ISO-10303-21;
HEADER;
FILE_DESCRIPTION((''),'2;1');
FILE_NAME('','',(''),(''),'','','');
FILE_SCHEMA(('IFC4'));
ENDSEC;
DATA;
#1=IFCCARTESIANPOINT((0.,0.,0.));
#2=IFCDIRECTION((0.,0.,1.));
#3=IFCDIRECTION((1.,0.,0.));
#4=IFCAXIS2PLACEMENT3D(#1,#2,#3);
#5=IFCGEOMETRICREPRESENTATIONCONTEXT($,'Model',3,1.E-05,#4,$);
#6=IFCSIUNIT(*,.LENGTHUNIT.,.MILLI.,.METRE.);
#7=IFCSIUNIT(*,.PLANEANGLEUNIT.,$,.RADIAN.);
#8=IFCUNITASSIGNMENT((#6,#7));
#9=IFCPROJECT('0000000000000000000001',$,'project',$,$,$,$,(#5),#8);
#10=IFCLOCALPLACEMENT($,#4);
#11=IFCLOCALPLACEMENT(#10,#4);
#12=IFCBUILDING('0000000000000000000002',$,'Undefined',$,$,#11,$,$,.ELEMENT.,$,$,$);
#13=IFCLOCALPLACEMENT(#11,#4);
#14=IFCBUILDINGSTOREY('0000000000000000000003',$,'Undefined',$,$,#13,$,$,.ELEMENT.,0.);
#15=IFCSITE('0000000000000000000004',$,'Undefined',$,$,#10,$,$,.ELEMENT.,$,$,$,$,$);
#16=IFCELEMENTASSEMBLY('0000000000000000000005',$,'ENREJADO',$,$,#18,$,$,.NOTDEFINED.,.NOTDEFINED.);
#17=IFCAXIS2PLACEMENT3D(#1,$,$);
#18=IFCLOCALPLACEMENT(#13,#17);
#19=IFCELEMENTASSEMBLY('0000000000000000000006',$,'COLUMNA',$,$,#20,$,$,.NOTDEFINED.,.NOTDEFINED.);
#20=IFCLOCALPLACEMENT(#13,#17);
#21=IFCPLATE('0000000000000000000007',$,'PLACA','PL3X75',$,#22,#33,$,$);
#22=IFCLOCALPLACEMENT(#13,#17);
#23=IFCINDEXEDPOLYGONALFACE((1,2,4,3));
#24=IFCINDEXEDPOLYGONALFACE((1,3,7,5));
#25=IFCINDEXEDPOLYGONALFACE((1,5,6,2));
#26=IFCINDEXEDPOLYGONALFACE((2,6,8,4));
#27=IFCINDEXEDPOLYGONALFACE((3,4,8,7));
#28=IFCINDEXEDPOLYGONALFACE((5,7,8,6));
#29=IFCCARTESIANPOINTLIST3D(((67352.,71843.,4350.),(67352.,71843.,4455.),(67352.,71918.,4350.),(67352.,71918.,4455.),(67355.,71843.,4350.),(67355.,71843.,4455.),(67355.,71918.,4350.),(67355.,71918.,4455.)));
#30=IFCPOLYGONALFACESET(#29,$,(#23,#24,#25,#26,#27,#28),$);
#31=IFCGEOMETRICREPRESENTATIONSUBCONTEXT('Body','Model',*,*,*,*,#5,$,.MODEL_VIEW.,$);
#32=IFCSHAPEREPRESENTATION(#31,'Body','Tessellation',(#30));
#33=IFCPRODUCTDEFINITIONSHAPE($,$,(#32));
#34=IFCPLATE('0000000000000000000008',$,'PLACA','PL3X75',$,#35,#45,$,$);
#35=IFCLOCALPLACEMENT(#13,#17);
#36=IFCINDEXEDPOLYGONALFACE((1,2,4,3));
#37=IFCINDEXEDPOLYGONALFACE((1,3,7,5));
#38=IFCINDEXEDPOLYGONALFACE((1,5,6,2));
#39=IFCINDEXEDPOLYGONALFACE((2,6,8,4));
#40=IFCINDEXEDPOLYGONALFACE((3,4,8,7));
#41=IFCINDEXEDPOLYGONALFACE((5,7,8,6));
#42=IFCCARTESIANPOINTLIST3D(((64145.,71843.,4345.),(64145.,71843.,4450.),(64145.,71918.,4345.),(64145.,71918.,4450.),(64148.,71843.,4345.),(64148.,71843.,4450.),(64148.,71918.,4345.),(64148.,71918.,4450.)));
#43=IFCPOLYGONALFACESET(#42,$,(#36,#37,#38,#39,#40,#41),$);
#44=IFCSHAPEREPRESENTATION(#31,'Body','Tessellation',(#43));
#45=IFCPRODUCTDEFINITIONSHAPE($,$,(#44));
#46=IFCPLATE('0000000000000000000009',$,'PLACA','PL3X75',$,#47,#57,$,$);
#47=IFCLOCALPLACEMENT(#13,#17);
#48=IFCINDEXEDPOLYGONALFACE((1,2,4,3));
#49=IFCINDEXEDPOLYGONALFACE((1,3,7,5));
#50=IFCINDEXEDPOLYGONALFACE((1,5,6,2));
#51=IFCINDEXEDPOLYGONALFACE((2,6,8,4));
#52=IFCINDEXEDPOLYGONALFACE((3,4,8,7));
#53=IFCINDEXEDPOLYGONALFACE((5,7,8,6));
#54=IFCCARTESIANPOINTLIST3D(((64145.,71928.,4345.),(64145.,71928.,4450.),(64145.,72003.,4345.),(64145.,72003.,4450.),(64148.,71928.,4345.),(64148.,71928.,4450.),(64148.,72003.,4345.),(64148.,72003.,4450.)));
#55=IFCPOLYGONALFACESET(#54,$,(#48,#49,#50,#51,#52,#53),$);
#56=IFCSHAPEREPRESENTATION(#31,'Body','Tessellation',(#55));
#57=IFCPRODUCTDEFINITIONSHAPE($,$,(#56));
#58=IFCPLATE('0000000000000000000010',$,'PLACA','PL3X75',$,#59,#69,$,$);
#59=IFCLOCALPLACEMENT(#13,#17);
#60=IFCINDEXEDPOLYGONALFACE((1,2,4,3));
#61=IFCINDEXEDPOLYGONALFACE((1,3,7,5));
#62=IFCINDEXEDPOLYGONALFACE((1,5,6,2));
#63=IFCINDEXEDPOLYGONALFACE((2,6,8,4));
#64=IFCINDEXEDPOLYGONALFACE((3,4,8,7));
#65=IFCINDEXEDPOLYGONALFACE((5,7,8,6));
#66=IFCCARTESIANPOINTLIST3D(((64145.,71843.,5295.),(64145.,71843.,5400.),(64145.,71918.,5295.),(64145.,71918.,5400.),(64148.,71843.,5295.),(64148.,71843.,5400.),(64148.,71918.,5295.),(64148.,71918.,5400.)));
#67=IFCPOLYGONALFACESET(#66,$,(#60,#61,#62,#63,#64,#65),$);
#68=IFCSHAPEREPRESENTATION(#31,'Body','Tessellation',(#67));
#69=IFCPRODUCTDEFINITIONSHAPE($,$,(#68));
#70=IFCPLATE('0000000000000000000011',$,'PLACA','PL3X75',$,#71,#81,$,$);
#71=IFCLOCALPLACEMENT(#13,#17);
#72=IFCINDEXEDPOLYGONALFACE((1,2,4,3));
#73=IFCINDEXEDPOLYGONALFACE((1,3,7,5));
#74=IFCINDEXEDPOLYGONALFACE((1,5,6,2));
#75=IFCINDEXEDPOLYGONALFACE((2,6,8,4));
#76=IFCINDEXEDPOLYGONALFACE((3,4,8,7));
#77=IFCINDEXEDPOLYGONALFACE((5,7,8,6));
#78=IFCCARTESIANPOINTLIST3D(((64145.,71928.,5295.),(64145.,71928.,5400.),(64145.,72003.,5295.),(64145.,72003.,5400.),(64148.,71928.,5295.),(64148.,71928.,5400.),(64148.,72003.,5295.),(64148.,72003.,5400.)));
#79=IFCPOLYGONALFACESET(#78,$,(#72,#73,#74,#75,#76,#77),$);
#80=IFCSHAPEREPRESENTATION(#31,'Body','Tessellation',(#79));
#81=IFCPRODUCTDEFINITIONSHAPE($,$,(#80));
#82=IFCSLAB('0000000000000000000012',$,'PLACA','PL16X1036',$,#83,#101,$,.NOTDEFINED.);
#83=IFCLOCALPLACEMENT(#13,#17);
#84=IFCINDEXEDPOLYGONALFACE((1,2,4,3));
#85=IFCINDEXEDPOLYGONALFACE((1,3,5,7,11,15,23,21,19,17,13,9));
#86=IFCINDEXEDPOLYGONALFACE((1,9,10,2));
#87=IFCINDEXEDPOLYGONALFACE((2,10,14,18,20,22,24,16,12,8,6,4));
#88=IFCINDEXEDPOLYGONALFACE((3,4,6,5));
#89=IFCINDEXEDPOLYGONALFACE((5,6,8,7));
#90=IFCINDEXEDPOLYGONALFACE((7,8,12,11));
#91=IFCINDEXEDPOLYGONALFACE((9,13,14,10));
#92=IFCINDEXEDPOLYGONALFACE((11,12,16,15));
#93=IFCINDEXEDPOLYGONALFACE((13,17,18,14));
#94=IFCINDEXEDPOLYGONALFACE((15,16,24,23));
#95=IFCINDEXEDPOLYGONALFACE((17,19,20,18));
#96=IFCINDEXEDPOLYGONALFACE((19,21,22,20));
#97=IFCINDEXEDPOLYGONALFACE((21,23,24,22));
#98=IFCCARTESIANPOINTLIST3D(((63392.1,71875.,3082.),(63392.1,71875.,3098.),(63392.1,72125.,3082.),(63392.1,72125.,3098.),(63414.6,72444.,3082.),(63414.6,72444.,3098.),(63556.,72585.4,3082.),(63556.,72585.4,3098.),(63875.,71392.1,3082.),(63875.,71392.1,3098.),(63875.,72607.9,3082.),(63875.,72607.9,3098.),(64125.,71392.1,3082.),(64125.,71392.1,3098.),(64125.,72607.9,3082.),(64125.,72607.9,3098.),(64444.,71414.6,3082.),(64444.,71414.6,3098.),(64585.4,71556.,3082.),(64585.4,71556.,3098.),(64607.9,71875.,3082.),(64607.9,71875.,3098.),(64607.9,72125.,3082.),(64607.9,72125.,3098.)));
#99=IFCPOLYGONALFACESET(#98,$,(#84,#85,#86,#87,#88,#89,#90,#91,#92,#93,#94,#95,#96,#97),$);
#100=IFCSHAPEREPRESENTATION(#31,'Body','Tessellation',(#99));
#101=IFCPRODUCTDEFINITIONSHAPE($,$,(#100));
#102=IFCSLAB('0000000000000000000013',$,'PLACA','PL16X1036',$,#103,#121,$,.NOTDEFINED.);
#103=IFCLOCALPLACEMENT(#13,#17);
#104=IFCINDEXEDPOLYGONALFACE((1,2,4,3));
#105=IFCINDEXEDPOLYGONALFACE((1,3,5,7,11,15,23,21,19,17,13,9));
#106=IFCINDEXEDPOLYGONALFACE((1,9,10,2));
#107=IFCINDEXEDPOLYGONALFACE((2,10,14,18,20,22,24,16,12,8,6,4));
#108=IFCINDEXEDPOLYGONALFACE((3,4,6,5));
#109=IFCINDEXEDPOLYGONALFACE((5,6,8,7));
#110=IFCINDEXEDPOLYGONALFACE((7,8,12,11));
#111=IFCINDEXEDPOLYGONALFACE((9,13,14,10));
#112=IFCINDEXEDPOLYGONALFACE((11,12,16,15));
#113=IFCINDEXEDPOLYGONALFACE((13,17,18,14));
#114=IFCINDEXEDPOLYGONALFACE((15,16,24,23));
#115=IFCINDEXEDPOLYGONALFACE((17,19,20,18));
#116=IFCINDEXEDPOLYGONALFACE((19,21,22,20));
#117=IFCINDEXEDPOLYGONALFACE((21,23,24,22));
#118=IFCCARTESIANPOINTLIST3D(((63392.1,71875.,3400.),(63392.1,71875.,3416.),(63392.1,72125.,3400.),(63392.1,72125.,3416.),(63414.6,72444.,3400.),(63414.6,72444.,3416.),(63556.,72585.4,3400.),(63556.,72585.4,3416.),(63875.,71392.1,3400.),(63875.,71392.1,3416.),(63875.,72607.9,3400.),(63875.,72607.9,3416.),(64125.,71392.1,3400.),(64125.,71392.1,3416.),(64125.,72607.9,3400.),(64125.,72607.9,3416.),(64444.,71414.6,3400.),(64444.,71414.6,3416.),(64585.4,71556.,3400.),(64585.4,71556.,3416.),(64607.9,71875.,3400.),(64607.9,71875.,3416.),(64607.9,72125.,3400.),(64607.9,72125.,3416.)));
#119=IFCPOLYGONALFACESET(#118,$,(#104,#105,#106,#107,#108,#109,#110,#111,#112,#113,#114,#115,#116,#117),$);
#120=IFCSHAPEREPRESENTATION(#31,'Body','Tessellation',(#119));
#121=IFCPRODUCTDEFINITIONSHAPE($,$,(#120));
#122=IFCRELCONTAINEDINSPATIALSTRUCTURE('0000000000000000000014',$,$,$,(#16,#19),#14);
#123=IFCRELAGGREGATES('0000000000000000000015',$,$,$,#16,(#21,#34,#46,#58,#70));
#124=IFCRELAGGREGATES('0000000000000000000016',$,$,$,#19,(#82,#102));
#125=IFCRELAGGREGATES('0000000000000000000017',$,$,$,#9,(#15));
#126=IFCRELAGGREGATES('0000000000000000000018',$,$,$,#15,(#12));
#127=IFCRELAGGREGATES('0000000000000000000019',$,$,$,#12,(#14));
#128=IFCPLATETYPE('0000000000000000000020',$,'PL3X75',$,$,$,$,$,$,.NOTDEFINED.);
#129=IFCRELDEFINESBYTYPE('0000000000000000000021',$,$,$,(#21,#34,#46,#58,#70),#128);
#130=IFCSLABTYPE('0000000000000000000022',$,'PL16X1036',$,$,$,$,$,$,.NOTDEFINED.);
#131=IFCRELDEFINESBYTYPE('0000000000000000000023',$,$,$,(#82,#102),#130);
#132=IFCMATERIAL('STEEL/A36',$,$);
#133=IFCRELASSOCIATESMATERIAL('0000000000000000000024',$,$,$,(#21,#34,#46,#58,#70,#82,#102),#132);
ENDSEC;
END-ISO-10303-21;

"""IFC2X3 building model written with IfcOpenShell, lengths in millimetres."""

from ifc_helpers import new_model, si_unit, frame, origin_with_axes, place, context, subcontext, project, spatial, polyline, outline, extrude, material, type_object, element, aggregate, save


model = new_model("IFC2X3")

# Units and contexts
model_context = context("Model", 3, precision=1e-05, world=origin_with_axes())
body_context = subcontext(model_context, "Body", "Model", "MODEL_VIEW")
ifc_project = project(units=[si_unit("LENGTHUNIT", "METRE", prefix="MILLI"), si_unit("PLANEANGLEUNIT", "RADIAN")], contexts=[model_context])

# Site, building, storey
site_placement = place(None, origin_with_axes())
site = spatial("IfcSite", under=ifc_project, at=site_placement, Name="Undefined", CompositionType="ELEMENT")
building_placement = place(site_placement, origin_with_axes())
building = spatial("IfcBuilding", under=site, at=building_placement, Name="Undefined", CompositionType="ELEMENT")
storey_placement = place(building_placement, origin_with_axes())
storey = spatial("IfcBuildingStorey", under=building, at=storey_placement, Name="Undefined", CompositionType="ELEMENT", Elevation=0.0)

# Element assembly
assembly_1_placement = place(storey_placement, origin_with_axes())
assembly_1 = element("IfcElementAssembly", 1, at=assembly_1_placement, inside=storey, Name="ENREJADO", AssemblyPlace="NOTDEFINED", PredefinedType="NOTDEFINED")
ifc_material_1 = material(Name="STEEL/A36")

# Element assembly
assembly_2_placement = place(storey_placement, origin_with_axes())
assembly_2 = element("IfcElementAssembly", 2, at=assembly_2_placement, inside=storey, Name="COLUMNA", AssemblyPlace="NOTDEFINED", PredefinedType="NOTDEFINED")

# Plates
plate_type_1 = type_object("IfcPlateType", Name="PL3X75", PredefinedType="NOTDEFINED")
plate_1_placement = place(assembly_1_placement, frame((67353.5, 71843.0, 4455.0), z_axis=(-1.0, 0.0, 0.0), x_axis=(0.0, 1.0, 0.0)))
plate_1 = element("IfcPlate", 3, at=plate_1_placement, type_object=plate_type_1, material=ifc_material_1, Name="PLACA", Description="PL3X75", context=body_context, shape_type="SweptSolid", body=[
    extrude(outline(polyline([(0.0, 0.0), (75.0, 0.0), (75.0, 105.0), (0.0, 105.0), (0.0, 0.0)])), frame((0.0, 0.0, -1.5), z_axis=(0.0, 0.0, 1.0), x_axis=(1.0, 0.0, 0.0)), (0.0, 0.0, 1.0), 3.0),
])
plate_2_placement = place(assembly_1_placement, frame((64146.5, 71843.0, 4345.0), z_axis=(1.0, 0.0, 0.0), x_axis=(0.0, 1.0, 0.0)))
plate_2 = element("IfcPlate", 4, at=plate_2_placement, type_object=plate_type_1, material=ifc_material_1, Name="PLACA", Description="PL3X75", context=body_context, shape_type="SweptSolid", body=[
    extrude(outline(polyline([(0.0, 0.0), (75.0, 0.0), (75.0, 105.0), (0.0, 105.0), (0.0, 0.0)])), frame((0.0, 0.0, -1.5), z_axis=(0.0, 0.0, 1.0), x_axis=(1.0, 0.0, 0.0)), (0.0, 0.0, 1.0), 3.0),
])
plate_3_placement = place(assembly_1_placement, frame((64146.5, 71928.0, 4345.0), z_axis=(1.0, 0.0, 0.0), x_axis=(0.0, 1.0, 0.0)))
plate_3 = element("IfcPlate", 5, at=plate_3_placement, type_object=plate_type_1, material=ifc_material_1, Name="PLACA", Description="PL3X75", context=body_context, shape_type="SweptSolid", body=[
    extrude(outline(polyline([(0.0, 0.0), (75.0, 0.0), (75.0, 105.0), (0.0, 105.0), (0.0, 0.0)])), frame((0.0, 0.0, -1.5), z_axis=(0.0, 0.0, 1.0), x_axis=(1.0, 0.0, 0.0)), (0.0, 0.0, 1.0), 3.0),
])
plate_4_placement = place(assembly_1_placement, frame((64146.5, 71843.0, 5295.0), z_axis=(1.0, 0.0, 0.0), x_axis=(0.0, 1.0, 0.0)))
plate_4 = element("IfcPlate", 6, at=plate_4_placement, type_object=plate_type_1, material=ifc_material_1, Name="PLACA", Description="PL3X75", context=body_context, shape_type="SweptSolid", body=[
    extrude(outline(polyline([(0.0, 0.0), (75.0, 0.0), (75.0, 105.0), (0.0, 105.0), (0.0, 0.0)])), frame((0.0, 0.0, -1.5), z_axis=(0.0, 0.0, 1.0), x_axis=(1.0, 0.0, 0.0)), (0.0, 0.0, 1.0), 3.0),
])
plate_5_placement = place(assembly_1_placement, frame((64146.5, 71928.0, 5295.0), z_axis=(1.0, 0.0, 0.0), x_axis=(0.0, 1.0, 0.0)))
plate_5 = element("IfcPlate", 7, at=plate_5_placement, type_object=plate_type_1, material=ifc_material_1, Name="PLACA", Description="PL3X75", context=body_context, shape_type="SweptSolid", body=[
    extrude(outline(polyline([(0.0, 0.0), (75.0, 0.0), (75.0, 105.0), (0.0, 105.0), (0.0, 0.0)])), frame((0.0, 0.0, -1.5), z_axis=(0.0, 0.0, 1.0), x_axis=(1.0, 0.0, 0.0)), (0.0, 0.0, 1.0), 3.0),
])
aggregate(assembly_1, [plate_1, plate_2, plate_3, plate_4, plate_5])

# Slabs
slab_type = type_object("IfcSlabType", Name="PL16X1036", PredefinedType="NOTDEFINED")
slab_1_placement = place(assembly_2_placement, frame((64125.0, 71392.1, 3090.0), z_axis=(0.0, 0.0, 1.0), x_axis=(0.997524, 0.070321, 0.0)))
slab_1 = element("IfcSlab", 8, at=slab_1_placement, type_object=slab_type, material=ifc_material_1, Name="PLACA", Description="PL16X1036", PredefinedType="NOTDEFINED", context=body_context, shape_type="SweptSolid", body=[
    extrude(outline(polyline([(0.0, 0.0), (319.8, 0.0), (470.8, 131.1), (515.7, 447.8), (533.2, 697.1), (85.5, 1212.8), (-163.9, 1230.4), (-483.7, 1230.4), (-634.7, 1099.3), (-679.6, 782.6), (-697.1, 533.2), (-249.4, 17.6), (0.0, 0.0)])), frame((0.0, 0.0, -8.0), z_axis=(0.0, 0.0, 1.0), x_axis=(1.0, 0.0, 0.0)), (0.0, 0.0, 1.0), 16.0),
])
slab_2_placement = place(assembly_2_placement, frame((64125.0, 71392.1, 3408.0), z_axis=(0.0, 0.0, 1.0), x_axis=(0.997524, 0.070321, 0.0)))
slab_2 = element("IfcSlab", 9, at=slab_2_placement, type_object=slab_type, material=ifc_material_1, Name="PLACA", Description="PL16X1036", PredefinedType="NOTDEFINED", context=body_context, shape_type="SweptSolid", body=[
    extrude(outline(polyline([(0.0, 0.0), (319.8, 0.0), (470.8, 131.1), (515.7, 447.8), (533.2, 697.1), (85.5, 1212.8), (-163.9, 1230.4), (-483.7, 1230.4), (-634.7, 1099.3), (-679.6, 782.6), (-697.1, 533.2), (-249.4, 17.6), (0.0, 0.0)])), frame((0.0, 0.0, -8.0), z_axis=(0.0, 0.0, 1.0), x_axis=(1.0, 0.0, 0.0)), (0.0, 0.0, 1.0), 16.0),
])

aggregate(assembly_2, [slab_1, slab_2])

save(model, "model.ifc")
